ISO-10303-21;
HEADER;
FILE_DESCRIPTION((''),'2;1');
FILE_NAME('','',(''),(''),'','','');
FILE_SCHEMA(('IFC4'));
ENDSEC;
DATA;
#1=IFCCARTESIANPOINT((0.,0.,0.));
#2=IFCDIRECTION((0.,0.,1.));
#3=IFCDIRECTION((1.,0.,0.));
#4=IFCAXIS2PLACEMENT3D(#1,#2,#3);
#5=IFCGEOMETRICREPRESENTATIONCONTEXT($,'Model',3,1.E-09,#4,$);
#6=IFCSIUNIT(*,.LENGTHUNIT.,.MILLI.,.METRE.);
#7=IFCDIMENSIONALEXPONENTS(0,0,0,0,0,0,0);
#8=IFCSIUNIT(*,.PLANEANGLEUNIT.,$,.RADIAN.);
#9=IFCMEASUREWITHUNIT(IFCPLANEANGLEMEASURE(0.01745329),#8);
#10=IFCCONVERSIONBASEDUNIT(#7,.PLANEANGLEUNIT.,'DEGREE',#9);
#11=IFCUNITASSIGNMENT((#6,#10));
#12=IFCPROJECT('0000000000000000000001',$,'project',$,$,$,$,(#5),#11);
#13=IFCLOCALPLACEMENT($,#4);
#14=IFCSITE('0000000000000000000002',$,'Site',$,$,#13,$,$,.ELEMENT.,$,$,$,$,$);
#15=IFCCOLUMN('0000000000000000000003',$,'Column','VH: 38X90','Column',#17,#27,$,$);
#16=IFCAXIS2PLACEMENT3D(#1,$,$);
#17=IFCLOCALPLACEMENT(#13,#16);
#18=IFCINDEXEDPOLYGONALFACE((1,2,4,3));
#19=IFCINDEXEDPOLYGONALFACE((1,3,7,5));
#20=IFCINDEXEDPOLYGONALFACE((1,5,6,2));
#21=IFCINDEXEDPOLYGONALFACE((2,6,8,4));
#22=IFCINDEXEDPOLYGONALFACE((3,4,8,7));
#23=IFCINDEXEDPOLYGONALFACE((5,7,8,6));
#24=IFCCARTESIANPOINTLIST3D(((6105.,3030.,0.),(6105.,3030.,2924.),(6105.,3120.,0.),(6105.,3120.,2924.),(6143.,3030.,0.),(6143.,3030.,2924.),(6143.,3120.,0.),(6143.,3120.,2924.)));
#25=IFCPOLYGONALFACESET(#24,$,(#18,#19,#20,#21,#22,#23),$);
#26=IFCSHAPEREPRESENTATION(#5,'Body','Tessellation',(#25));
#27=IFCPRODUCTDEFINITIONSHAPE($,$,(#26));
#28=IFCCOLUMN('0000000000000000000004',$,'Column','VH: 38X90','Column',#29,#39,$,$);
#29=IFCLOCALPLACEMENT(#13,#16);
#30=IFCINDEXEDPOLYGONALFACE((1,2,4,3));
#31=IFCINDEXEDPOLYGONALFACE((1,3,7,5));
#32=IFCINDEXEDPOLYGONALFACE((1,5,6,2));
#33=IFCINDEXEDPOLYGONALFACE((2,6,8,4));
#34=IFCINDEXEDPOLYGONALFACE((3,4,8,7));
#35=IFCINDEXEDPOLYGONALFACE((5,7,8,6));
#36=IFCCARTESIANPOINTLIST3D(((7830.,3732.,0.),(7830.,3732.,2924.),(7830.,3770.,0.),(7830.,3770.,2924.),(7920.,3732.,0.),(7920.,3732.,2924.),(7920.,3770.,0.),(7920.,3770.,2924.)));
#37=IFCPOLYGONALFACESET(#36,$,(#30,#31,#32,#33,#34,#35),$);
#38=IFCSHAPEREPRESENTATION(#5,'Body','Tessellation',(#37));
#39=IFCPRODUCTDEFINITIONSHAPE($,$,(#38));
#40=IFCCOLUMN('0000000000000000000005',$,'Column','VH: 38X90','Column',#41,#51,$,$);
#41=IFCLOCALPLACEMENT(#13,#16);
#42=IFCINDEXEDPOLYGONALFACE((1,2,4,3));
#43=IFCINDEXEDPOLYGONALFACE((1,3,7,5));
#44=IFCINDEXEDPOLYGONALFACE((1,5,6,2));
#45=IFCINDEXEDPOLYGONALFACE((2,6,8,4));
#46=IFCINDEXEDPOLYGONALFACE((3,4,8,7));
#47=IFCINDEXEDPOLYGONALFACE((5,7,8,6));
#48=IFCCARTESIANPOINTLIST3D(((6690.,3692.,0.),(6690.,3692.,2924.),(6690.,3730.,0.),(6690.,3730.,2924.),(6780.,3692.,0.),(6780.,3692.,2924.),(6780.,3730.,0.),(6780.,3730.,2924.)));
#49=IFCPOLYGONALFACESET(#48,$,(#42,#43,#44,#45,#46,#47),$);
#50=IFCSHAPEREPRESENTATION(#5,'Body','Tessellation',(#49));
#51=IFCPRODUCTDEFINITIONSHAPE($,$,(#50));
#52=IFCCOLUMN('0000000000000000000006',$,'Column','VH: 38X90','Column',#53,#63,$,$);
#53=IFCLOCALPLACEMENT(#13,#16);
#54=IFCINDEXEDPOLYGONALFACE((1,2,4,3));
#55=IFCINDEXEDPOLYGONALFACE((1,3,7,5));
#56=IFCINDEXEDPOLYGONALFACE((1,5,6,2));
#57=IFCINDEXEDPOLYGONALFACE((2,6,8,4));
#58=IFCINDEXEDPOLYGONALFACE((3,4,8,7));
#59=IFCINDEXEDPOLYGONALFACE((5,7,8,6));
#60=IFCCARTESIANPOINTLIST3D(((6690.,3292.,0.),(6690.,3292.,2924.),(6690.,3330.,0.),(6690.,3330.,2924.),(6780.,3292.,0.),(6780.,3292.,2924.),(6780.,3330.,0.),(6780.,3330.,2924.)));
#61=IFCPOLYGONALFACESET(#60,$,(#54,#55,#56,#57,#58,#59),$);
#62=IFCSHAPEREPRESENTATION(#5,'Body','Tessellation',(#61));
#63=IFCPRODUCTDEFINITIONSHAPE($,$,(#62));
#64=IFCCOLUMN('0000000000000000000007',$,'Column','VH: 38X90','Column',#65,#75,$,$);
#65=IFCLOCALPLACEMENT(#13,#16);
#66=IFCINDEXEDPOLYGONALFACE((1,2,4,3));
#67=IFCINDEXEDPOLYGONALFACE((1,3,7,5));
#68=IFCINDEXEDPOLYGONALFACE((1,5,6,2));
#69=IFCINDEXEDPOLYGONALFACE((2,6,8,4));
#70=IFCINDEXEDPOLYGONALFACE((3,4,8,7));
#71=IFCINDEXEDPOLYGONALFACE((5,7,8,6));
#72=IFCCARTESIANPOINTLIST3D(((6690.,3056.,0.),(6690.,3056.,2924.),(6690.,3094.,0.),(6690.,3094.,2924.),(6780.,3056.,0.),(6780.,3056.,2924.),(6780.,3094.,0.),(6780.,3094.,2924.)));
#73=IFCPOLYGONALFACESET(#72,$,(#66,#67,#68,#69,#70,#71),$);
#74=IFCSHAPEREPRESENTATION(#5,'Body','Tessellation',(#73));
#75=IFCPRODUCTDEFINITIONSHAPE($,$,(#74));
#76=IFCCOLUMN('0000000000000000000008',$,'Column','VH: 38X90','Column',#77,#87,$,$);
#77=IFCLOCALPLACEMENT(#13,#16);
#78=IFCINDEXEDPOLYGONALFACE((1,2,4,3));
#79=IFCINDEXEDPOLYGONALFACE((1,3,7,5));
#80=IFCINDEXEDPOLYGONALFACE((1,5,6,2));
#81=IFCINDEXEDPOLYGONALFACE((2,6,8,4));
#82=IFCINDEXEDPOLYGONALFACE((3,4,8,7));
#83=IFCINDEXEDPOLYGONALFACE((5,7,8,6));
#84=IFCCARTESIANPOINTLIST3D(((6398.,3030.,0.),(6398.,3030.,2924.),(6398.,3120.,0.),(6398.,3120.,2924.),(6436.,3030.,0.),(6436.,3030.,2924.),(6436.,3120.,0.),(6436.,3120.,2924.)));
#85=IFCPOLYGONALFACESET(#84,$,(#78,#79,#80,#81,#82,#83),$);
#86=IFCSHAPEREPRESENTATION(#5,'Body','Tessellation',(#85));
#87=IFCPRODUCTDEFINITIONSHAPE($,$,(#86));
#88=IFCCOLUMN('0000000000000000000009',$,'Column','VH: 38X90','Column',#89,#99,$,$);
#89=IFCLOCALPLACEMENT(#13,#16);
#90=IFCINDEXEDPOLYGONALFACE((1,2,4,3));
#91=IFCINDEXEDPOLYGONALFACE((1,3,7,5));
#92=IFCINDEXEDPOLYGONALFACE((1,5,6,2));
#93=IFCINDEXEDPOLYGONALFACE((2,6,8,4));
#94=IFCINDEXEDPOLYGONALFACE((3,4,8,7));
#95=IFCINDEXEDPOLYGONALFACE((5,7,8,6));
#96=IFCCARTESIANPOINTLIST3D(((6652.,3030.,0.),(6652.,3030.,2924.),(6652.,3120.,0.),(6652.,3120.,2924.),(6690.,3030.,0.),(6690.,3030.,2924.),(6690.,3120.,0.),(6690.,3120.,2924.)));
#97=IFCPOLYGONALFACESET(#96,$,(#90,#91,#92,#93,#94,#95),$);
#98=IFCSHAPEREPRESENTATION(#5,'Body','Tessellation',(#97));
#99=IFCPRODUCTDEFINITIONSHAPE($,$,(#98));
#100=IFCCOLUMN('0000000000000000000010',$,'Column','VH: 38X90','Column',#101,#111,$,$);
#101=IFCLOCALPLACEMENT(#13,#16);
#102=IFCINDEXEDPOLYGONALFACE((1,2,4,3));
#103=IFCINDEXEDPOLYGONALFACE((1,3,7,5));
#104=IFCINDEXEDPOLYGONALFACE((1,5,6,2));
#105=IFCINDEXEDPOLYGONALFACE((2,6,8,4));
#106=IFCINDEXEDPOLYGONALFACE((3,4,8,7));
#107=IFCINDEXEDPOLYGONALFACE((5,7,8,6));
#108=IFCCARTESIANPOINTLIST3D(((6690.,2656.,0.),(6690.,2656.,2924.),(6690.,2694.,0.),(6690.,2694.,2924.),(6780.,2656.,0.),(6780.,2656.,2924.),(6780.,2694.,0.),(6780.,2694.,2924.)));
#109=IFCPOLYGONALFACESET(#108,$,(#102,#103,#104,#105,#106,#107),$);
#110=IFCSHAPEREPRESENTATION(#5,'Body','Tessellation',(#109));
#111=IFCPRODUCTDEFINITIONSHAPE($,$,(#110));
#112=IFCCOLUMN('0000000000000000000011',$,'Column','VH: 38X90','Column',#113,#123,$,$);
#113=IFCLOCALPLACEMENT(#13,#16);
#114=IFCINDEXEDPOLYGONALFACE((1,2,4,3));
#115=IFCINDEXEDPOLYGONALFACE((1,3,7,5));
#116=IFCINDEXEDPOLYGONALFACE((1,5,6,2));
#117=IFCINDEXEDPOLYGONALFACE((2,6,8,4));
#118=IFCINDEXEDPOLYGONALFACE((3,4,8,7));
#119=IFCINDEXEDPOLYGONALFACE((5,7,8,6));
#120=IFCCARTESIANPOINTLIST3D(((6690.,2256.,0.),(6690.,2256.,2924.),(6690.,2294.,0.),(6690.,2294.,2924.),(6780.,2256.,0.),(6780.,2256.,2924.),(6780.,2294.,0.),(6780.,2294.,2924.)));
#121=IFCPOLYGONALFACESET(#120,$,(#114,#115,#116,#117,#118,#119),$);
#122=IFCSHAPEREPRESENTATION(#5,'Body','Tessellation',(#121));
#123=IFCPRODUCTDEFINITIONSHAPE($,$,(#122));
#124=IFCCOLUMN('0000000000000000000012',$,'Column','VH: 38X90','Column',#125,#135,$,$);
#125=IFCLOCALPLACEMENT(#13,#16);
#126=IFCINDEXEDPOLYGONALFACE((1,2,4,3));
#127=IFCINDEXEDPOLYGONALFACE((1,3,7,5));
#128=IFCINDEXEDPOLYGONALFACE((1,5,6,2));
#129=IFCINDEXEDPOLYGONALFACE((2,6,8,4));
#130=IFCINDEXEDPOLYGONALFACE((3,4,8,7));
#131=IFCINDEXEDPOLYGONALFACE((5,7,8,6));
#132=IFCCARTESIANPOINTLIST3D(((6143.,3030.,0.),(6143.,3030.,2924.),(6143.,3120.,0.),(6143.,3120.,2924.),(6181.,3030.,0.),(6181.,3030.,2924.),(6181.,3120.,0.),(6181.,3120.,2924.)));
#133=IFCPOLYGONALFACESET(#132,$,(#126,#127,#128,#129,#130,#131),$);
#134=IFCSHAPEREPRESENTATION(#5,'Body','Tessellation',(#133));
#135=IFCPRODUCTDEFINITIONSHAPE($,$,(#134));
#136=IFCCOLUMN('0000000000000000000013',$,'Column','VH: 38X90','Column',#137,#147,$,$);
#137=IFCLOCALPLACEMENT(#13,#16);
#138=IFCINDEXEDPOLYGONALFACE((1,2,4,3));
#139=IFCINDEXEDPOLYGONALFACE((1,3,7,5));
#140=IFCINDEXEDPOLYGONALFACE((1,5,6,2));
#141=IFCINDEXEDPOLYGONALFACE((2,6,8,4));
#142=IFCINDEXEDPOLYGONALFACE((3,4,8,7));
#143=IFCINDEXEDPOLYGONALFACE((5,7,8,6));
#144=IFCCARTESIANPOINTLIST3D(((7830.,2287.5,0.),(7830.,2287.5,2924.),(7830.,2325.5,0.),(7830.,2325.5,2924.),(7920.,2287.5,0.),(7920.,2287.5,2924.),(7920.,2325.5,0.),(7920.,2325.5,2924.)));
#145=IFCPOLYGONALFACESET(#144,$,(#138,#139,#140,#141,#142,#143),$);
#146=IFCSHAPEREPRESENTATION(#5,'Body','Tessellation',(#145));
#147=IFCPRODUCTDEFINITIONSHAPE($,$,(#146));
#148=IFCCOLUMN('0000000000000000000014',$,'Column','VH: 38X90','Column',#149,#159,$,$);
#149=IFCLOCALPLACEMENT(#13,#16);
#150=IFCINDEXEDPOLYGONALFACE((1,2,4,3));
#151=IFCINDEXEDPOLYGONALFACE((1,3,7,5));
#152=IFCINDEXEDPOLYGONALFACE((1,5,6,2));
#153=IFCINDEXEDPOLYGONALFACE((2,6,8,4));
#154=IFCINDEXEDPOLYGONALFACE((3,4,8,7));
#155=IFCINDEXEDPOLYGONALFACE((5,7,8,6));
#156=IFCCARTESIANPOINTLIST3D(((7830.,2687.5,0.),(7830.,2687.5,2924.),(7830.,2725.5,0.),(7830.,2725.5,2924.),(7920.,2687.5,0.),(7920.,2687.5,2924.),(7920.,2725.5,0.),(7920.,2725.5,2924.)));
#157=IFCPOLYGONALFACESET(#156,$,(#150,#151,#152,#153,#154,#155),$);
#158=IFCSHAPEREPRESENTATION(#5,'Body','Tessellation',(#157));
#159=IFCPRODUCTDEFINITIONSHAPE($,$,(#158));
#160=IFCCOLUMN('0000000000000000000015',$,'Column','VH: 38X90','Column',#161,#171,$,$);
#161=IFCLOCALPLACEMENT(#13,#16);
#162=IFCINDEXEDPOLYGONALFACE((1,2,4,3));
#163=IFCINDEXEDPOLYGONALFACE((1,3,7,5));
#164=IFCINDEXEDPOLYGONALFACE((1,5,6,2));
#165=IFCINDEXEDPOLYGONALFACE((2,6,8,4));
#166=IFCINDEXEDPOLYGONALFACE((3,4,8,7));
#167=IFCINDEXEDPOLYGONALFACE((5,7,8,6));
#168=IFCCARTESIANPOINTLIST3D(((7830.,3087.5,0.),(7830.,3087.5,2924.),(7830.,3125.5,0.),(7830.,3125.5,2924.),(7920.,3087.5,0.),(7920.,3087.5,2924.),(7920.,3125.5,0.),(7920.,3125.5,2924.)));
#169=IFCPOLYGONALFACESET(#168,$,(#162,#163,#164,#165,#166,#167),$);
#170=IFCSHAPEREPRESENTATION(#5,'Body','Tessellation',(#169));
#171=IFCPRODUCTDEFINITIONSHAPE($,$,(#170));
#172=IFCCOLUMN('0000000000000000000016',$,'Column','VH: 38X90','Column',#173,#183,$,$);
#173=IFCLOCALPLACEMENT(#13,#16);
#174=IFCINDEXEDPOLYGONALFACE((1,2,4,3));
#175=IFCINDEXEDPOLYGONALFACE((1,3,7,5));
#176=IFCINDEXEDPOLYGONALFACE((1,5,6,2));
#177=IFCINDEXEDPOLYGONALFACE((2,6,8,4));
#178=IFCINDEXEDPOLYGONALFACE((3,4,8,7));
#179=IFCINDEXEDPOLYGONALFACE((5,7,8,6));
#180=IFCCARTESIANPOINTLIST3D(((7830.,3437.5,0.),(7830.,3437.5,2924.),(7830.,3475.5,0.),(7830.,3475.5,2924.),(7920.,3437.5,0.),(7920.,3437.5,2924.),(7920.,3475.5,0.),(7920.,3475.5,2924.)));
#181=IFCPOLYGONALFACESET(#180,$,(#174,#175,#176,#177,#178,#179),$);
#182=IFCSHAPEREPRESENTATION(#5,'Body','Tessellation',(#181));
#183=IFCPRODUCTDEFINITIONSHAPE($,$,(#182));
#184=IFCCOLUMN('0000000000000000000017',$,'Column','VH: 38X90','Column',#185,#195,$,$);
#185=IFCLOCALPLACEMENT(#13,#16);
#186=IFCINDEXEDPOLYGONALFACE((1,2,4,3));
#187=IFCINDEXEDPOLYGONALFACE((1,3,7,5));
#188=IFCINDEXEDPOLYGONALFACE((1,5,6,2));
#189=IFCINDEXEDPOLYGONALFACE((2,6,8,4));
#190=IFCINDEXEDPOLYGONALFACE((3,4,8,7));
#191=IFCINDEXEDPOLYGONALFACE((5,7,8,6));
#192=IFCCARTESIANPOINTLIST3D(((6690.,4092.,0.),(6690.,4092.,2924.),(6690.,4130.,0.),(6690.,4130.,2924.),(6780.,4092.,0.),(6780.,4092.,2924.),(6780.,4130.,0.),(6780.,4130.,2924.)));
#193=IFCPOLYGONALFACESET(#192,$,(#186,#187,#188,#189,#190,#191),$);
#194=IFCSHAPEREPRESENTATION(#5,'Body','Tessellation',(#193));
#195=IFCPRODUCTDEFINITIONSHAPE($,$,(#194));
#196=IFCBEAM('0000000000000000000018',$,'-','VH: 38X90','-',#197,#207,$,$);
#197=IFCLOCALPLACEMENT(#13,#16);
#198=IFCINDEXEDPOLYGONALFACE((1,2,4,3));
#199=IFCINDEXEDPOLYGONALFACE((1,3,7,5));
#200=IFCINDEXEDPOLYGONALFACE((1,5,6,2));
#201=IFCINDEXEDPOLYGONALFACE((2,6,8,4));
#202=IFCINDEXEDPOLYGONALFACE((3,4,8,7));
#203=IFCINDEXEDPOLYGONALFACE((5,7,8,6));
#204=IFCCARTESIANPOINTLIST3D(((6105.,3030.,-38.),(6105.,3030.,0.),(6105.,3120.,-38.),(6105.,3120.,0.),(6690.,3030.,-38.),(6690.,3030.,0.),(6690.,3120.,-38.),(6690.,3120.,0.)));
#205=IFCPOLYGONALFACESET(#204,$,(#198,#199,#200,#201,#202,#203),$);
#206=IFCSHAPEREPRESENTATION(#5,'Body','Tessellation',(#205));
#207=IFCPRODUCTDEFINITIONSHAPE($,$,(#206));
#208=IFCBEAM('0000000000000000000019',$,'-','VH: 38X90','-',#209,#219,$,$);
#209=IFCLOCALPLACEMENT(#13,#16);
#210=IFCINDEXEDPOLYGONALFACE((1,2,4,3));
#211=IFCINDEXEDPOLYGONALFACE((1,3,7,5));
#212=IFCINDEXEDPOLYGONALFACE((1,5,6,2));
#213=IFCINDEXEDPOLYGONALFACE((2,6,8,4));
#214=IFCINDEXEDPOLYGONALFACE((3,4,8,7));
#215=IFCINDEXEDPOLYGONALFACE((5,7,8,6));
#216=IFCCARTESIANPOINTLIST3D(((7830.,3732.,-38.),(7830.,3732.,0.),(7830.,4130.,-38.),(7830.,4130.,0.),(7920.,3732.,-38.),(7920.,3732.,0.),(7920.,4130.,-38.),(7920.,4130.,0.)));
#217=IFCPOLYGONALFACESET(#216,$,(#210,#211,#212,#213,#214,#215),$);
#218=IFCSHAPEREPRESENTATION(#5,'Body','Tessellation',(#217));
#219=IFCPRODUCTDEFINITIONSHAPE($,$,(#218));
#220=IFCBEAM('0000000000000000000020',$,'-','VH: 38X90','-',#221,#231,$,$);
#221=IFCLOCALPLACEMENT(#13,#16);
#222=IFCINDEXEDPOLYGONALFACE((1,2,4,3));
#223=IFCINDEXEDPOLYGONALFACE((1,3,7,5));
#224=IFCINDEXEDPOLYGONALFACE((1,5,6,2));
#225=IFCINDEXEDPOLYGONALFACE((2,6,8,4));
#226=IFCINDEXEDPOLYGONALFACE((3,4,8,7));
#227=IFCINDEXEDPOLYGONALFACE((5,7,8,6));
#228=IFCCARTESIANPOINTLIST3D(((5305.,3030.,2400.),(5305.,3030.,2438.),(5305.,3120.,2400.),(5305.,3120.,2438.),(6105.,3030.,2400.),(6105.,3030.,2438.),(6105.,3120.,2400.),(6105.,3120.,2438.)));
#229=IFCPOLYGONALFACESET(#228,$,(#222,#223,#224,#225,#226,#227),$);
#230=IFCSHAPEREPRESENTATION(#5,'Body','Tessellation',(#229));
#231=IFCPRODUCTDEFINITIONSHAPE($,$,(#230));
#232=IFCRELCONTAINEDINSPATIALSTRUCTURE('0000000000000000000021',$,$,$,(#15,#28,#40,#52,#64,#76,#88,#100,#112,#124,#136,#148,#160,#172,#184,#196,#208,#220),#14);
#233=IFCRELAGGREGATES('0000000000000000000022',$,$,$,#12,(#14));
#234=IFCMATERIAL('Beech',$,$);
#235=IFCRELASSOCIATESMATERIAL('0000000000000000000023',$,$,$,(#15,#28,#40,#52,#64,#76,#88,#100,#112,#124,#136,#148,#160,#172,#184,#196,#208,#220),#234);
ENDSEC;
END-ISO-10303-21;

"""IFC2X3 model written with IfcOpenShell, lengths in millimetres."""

from ifc_helpers import new_model, entity, si_unit, converted_unit, frame, origin, origin_with_axes, origin_2d, place, context, project, spatial, rectangle, extrude, material, element, save


model = new_model("IFC2X3")

# Units and contexts
model_context = context("Model", 3, precision=1e-09, world=origin_with_axes())
ifc_project = project(units=[si_unit("LENGTHUNIT", "METRE", prefix="MILLI"), converted_unit("PLANEANGLEUNIT", "DEGREE", entity("IfcPlaneAngleMeasure", 0.01745329), si_unit("PLANEANGLEUNIT", "RADIAN"), dimensions=[0, 0, 0, 0, 0, 0, 0])], contexts=[model_context])

# Site
site_placement = place(None, origin_with_axes())
site = spatial("IfcSite", under=ifc_project, at=site_placement, Name="Site", CompositionType="ELEMENT")

# Columns
ifc_material_1 = material(Name="Beech")
for number, where, z_axis, x_axis, name in (
    (1, (6124.0, 3075.0, 0.0), (0.0, 0.0, -1.0), (-1.0, 0.0, 0.0), "Column"),
    (2, (7875.0, 3751.0, 0.0), (0.0, 0.0, -1.0), (0.0, -1.0, 0.0), "Column"),
    (3, (6735.0, 3711.0, 0.0), (0.0, 0.0, -1.0), (0.0, -1.0, 0.0), "Column"),
    (4, (6735.0, 3311.0, 0.0), (0.0, 0.0, -1.0), (0.0, -1.0, 0.0), "Column"),
    (5, (6735.0, 3075.0, 0.0), (0.0, 0.0, -1.0), (0.0, -1.0, 0.0), "Column"),
    (6, (6417.0, 3075.0, 0.0), (0.0, 0.0, -1.0), (-1.0, 0.0, 0.0), "Column"),
    (7, (6671.0, 3075.0, 0.0), (0.0, 0.0, -1.0), (-1.0, 0.0, 0.0), "Column"),
    (8, (6735.0, 2675.0, 0.0), (0.0, 0.0, -1.0), (0.0, -1.0, 0.0), "Column"),
    (9, (6735.0, 2275.0, 0.0), (0.0, 0.0, -1.0), (0.0, -1.0, 0.0), "Column"),
):
    element("IfcColumn", number, at=place(None, frame(where, z_axis=z_axis, x_axis=x_axis)), inside=site, material=ifc_material_1, Name=name, Description="VH: 38X90", ObjectType="Column", context=model_context, shape_type="SweptSolid", body=[
        extrude(rectangle(XDim=38.0, YDim=90.0, at=origin_2d()), origin(), (0.0, 0.0, -1.0), 2924.0),
    ])
for number, where, z_axis, x_axis, name in (
    (10, (6162.0, 3075.0, 0.0), (0.0, 0.0, -1.0), (-1.0, 0.0, 0.0), "Column"),
    (11, (7875.0, 2306.5, 0.0), (0.0, 0.0, -1.0), (0.0, -1.0, 0.0), "Column"),
    (12, (7875.0, 2706.5, 0.0), (0.0, 0.0, -1.0), (0.0, -1.0, 0.0), "Column"),
    (13, (7875.0, 3106.5, 0.0), (0.0, 0.0, -1.0), (0.0, -1.0, 0.0), "Column"),
    (14, (7875.0, 3456.5, 0.0), (0.0, 0.0, -1.0), (0.0, -1.0, 0.0), "Column"),
    (15, (6735.0, 4111.0, 0.0), (0.0, 0.0, -1.0), (0.0, -1.0, 0.0), "Column"),
):
    element("IfcColumn", number, at=place(None, frame(where, z_axis=z_axis, x_axis=x_axis)), inside=site, material=ifc_material_1, Name=name, Description="VH: 38X90", ObjectType="Column", context=model_context, shape_type="SweptSolid", body=[
        extrude(rectangle(XDim=38.0, YDim=90.0, at=origin_2d()), origin(), (0.0, 0.0, -1.0), 2924.0),
    ])

# Beams
beam_1_placement = place(None, frame((6105.0, 3075.0, -19.0), z_axis=(-1.0, 0.0, 0.0), x_axis=(0.0, 0.0, -1.0)))
element("IfcBeam", 16, at=beam_1_placement, inside=site, material=ifc_material_1, Name="-", Description="VH: 38X90", ObjectType="-", context=model_context, shape_type="SweptSolid", body=[
    extrude(rectangle(XDim=38.0, YDim=90.0, at=origin_2d()), origin(), (0.0, 0.0, -1.0), 585.0),
])
beam_2_placement = place(None, frame((7875.0, 3732.0, -19.0), z_axis=(0.0, -1.0, 0.0), x_axis=(0.0, 0.0, -1.0)))
element("IfcBeam", 17, at=beam_2_placement, inside=site, material=ifc_material_1, Name="-", Description="VH: 38X90", ObjectType="-", context=model_context, shape_type="SweptSolid", body=[
    extrude(rectangle(XDim=38.0, YDim=90.0, at=origin_2d()), origin(), (0.0, 0.0, -1.0), 398.0),
])
beam_3_placement = place(None, frame((5305.0, 3075.0, 2419.0), z_axis=(-1.0, -0.000033, 0.0), x_axis=(0.0, 0.0, -1.0)))
element("IfcBeam", 18, at=beam_3_placement, inside=site, material=ifc_material_1, Name="-", Description="VH: 38X90", ObjectType="-", context=model_context, shape_type="SweptSolid", body=[
    extrude(rectangle(XDim=38.0, YDim=90.0, at=origin_2d()), origin(), (0.0, 0.0, -1.0), 800.0),
])

save(model, "model.ifc")
